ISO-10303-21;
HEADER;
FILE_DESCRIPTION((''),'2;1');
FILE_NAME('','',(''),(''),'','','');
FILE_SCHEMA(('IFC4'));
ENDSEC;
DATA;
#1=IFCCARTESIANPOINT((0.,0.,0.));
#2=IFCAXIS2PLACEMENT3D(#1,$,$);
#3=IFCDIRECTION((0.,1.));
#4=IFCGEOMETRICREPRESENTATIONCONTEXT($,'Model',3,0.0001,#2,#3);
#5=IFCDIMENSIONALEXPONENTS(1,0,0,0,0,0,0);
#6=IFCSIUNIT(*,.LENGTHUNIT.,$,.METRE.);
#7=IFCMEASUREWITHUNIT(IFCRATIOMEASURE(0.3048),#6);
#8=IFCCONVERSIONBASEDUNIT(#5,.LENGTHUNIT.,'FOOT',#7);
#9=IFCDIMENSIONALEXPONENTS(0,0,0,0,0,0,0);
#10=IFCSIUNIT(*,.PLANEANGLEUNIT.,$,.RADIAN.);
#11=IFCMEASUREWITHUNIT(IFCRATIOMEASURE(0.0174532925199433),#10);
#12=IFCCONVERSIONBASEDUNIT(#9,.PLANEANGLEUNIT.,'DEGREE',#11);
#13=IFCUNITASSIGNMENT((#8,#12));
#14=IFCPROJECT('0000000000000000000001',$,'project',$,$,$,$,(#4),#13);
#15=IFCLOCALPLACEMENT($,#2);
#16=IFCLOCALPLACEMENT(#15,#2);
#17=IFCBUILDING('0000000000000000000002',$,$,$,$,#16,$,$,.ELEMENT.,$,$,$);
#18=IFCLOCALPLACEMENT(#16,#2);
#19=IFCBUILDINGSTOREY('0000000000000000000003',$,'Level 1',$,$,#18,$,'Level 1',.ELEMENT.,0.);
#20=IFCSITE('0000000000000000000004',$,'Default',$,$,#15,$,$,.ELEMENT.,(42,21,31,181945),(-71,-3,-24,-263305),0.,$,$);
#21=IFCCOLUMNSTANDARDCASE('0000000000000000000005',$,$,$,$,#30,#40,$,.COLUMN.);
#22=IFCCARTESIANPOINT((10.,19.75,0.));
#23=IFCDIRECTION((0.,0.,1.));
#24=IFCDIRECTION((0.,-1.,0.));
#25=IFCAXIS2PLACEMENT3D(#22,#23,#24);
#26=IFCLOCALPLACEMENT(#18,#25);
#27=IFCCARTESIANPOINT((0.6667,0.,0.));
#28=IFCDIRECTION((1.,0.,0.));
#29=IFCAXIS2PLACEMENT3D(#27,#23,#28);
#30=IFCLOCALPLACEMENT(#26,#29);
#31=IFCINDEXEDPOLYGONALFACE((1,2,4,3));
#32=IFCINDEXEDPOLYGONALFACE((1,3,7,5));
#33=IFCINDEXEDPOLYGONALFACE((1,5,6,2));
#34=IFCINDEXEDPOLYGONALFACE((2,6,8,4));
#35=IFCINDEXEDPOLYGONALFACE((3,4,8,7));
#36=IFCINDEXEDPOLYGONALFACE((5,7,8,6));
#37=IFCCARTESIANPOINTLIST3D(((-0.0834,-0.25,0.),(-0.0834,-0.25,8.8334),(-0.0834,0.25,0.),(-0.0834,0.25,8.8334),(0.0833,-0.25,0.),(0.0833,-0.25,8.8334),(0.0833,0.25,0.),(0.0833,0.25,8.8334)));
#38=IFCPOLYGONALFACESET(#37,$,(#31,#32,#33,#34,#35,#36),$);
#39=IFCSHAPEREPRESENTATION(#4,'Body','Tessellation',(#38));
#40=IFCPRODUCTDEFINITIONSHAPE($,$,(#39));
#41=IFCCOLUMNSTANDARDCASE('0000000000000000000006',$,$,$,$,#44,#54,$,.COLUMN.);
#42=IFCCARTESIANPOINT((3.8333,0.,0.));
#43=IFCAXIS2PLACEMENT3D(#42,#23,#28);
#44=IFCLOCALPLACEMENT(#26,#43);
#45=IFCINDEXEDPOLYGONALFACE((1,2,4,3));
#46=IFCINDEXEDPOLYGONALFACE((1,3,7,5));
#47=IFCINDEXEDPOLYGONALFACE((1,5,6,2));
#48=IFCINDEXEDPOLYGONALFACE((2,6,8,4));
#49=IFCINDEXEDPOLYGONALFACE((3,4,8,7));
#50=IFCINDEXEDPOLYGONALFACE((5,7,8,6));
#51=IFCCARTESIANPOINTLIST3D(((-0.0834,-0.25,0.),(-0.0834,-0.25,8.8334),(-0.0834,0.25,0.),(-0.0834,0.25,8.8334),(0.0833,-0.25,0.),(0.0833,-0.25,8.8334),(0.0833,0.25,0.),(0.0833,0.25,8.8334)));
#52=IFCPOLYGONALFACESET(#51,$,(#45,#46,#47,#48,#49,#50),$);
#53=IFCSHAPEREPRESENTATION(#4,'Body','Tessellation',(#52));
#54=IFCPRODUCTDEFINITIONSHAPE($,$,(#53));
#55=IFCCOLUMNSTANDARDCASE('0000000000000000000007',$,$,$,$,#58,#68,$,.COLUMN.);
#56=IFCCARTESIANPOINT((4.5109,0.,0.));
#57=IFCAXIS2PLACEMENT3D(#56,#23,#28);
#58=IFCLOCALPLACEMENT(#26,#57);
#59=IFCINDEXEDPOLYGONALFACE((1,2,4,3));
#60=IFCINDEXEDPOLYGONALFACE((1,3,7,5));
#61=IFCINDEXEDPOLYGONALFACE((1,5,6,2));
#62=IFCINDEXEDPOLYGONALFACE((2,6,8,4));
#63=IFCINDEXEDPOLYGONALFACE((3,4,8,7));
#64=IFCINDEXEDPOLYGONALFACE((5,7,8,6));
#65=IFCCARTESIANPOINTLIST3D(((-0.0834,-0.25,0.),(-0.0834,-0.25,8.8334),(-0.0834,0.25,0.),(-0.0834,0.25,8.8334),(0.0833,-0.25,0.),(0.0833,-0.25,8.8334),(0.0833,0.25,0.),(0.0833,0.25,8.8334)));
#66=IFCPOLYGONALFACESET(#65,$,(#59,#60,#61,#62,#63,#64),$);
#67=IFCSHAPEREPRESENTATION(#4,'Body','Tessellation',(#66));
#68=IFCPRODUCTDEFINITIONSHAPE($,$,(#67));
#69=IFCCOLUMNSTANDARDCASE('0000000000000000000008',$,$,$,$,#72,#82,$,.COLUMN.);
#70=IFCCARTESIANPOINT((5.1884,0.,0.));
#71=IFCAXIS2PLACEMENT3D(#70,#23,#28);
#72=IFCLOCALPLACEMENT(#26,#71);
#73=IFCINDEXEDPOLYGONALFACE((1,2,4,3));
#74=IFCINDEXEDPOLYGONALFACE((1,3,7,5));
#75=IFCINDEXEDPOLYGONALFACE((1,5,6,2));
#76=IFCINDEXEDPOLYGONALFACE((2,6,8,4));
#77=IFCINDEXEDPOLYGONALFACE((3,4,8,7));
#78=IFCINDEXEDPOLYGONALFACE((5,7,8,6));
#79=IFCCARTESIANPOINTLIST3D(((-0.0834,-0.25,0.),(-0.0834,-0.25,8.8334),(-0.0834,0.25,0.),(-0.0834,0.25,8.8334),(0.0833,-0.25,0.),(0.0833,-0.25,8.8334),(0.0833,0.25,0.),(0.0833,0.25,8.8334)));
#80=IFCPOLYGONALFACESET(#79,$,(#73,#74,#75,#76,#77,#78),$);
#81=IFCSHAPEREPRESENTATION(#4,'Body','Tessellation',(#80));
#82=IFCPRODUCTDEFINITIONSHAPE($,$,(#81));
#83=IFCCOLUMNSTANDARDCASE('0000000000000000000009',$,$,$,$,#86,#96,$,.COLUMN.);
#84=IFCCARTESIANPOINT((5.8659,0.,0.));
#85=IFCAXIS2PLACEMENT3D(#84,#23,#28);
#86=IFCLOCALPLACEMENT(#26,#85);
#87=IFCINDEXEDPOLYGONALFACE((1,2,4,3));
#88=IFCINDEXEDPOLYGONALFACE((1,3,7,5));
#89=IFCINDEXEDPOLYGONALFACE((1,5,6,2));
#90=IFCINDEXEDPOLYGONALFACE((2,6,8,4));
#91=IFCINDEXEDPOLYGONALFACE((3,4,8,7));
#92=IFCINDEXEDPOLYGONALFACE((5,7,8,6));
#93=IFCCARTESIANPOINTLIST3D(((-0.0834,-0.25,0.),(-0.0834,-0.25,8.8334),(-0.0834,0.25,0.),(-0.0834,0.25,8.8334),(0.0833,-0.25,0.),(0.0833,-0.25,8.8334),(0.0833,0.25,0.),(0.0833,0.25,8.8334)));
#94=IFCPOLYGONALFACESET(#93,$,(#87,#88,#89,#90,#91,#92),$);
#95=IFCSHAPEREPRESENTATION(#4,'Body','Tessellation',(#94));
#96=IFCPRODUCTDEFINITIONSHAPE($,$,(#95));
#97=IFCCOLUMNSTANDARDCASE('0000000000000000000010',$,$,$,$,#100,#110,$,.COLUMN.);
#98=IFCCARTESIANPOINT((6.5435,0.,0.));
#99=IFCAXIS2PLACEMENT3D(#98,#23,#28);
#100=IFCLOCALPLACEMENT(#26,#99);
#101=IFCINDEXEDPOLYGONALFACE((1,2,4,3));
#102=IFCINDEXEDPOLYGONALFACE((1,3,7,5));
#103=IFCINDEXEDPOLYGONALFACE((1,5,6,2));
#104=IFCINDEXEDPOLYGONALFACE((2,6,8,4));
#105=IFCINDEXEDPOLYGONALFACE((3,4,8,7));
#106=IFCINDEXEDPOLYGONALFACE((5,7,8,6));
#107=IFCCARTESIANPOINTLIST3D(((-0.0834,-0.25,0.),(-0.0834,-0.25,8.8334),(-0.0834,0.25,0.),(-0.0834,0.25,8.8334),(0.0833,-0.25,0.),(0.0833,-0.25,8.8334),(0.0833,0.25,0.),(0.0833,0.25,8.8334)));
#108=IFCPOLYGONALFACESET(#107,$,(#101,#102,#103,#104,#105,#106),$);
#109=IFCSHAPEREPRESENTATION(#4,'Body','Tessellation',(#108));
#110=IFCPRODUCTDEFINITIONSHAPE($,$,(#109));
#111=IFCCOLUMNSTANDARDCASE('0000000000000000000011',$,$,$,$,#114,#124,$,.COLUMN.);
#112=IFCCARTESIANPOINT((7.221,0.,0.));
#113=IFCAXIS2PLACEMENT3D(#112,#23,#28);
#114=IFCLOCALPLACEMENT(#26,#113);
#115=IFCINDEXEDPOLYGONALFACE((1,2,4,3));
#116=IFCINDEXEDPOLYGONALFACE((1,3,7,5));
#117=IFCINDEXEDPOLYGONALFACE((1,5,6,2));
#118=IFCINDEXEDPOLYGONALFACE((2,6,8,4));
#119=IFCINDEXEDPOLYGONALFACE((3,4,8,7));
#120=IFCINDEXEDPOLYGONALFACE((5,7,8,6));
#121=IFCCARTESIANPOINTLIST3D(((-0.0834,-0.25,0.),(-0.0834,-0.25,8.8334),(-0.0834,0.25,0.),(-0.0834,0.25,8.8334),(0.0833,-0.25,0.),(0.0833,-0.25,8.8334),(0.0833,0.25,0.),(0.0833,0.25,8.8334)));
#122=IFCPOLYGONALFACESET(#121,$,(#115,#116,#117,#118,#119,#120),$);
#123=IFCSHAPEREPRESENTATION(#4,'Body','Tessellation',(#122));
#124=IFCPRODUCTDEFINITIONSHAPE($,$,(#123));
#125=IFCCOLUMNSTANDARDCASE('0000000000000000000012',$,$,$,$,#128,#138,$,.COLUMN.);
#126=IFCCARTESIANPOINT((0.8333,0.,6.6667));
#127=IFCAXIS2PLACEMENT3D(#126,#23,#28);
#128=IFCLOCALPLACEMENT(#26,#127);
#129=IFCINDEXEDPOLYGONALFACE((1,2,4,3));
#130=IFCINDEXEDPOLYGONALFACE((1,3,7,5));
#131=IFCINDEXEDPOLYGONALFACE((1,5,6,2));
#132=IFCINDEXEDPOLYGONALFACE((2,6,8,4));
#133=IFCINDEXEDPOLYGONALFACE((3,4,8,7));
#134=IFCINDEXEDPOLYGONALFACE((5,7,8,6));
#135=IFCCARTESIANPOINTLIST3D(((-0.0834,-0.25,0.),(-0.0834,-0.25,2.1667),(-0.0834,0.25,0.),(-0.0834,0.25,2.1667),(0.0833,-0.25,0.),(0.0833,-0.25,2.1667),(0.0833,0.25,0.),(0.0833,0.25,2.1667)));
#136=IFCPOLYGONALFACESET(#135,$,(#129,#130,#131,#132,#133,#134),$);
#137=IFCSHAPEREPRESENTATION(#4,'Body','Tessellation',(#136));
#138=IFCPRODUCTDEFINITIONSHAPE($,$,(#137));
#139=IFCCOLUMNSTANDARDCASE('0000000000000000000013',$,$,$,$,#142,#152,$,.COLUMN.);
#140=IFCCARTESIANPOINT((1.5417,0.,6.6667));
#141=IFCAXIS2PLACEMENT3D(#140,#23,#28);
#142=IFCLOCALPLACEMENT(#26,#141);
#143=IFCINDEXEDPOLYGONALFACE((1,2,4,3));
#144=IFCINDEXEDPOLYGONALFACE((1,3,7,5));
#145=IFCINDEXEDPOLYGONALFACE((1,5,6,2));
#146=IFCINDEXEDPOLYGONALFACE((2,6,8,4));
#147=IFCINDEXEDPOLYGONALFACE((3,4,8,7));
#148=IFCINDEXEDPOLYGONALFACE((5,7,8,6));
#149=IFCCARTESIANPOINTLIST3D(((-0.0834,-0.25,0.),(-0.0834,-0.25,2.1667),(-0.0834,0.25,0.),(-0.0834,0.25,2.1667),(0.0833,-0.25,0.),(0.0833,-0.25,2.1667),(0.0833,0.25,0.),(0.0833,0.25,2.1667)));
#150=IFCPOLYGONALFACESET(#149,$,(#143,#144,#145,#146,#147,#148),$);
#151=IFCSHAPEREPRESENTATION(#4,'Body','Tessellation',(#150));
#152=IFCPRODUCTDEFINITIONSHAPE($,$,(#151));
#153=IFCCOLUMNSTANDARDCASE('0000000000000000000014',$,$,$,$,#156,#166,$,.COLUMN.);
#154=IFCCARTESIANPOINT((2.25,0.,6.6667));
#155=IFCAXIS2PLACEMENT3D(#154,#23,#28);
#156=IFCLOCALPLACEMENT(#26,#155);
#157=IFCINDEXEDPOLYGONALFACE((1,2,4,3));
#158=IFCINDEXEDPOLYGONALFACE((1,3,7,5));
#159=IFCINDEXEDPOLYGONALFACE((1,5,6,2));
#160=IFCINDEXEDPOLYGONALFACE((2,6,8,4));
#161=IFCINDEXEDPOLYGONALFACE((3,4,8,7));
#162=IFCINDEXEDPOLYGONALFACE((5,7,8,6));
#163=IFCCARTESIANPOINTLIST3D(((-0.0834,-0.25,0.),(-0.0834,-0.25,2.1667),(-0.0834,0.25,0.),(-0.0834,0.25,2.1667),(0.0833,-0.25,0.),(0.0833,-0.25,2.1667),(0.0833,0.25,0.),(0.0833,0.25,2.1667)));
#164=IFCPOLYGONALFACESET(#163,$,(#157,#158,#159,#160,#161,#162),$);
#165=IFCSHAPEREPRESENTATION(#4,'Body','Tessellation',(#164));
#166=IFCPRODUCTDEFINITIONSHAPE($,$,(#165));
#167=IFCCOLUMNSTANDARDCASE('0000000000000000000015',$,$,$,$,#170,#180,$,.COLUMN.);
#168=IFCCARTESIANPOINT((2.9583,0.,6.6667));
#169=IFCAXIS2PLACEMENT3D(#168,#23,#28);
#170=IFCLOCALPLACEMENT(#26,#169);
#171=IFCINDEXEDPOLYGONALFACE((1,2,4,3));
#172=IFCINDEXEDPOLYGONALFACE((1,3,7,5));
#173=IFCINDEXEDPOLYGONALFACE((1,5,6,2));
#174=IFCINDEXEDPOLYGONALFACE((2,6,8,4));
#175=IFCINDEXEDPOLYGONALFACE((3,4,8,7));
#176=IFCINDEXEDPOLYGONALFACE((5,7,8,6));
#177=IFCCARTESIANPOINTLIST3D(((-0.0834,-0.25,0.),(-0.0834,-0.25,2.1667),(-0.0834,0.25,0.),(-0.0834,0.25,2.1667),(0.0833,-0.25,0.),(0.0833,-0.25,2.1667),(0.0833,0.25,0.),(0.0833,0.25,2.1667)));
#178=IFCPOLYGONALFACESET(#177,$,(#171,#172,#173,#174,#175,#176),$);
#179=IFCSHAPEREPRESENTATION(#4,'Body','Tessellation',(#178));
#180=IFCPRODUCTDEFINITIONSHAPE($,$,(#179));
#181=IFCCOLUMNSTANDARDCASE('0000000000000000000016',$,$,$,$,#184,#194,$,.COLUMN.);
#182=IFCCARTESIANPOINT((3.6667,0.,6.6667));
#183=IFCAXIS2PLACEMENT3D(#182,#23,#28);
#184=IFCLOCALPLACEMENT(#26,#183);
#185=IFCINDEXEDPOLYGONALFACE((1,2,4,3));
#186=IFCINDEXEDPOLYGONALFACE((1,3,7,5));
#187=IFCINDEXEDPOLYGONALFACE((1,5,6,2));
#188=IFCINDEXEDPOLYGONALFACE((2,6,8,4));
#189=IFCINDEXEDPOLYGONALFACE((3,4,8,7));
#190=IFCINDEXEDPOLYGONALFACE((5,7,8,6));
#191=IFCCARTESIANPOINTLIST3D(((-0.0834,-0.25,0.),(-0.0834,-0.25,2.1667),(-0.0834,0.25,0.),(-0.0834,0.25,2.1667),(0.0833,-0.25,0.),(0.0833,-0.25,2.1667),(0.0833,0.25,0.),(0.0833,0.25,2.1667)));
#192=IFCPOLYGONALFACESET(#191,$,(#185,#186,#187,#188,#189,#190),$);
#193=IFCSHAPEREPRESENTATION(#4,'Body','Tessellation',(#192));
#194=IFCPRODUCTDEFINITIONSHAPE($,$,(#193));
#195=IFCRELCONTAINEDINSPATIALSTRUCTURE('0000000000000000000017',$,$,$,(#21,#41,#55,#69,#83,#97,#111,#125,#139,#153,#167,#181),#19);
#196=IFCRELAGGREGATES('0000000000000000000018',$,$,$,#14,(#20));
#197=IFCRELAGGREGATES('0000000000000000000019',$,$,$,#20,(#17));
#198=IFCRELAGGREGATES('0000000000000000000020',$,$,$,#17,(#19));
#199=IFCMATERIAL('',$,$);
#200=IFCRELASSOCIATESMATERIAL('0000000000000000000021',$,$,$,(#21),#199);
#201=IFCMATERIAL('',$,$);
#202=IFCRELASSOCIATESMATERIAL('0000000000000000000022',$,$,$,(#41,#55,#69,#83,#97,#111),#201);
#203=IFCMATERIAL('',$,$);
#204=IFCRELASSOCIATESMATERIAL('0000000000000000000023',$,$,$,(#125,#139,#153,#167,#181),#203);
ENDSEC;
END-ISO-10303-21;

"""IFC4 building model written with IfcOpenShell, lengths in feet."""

from ifc_helpers import new_model, entity, si_unit, converted_unit, direction, frame, origin, place, context, project, spatial, rectangle, extrude, material, element, save


model = new_model("IFC4")

# Units and contexts
model_context = context("Model", 3, precision=0.0001, world=origin(), true_north=direction((0.0, 1.0)))
ifc_project = project(units=[converted_unit("LENGTHUNIT", "FOOT", entity("IfcRatioMeasure", 0.3048), si_unit("LENGTHUNIT", "METRE"), dimensions=[1, 0, 0, 0, 0, 0, 0]), converted_unit("PLANEANGLEUNIT", "DEGREE", entity("IfcRatioMeasure", 0.0174532925199433), si_unit("PLANEANGLEUNIT", "RADIAN"), dimensions=[0, 0, 0, 0, 0, 0, 0])], contexts=[model_context])

# Site, building, storey
site_placement = place(None, origin())
site = spatial("IfcSite", under=ifc_project, at=site_placement, Name="Default", CompositionType="ELEMENT", RefLatitude=(42, 21, 31, 181945), RefLongitude=(-71, -3, -24, -263305), RefElevation=0.0)
building_placement = place(site_placement, origin())
building = spatial("IfcBuilding", under=site, at=building_placement, CompositionType="ELEMENT")
storey_placement = place(building_placement, origin())
storey = spatial("IfcBuildingStorey", under=building, at=storey_placement, Name="Level 1", LongName="Level 1", CompositionType="ELEMENT", Elevation=0.0)

# Columns
ifc_material_1 = material(Name="")
ifc_material_2 = material(Name="")
placement_1 = place(storey_placement, frame((10.0, 19.75, 0.0), z_axis=(0.0, 0.0, 1.0), x_axis=(0.0, -1.0, 0.0)))
for number, where, z_axis, x_axis in (
    (1, (0.6667, 0.0, 0.0), (0.0, 0.0, 1.0), (1.0, 0.0, 0.0)),
):
    element("IfcColumnStandardCase", number, at=place(placement_1, frame(where, z_axis=z_axis, x_axis=x_axis)), inside=storey, material=ifc_material_1, PredefinedType="COLUMN", context=model_context, shape_type="SweptSolid", body=[
        extrude(rectangle(XDim=0.1667, YDim=0.5), origin(), (0.0, 0.0, 1.0), 8.8334),
    ])
for number, where, z_axis, x_axis in (
    (2, (3.8333, 0.0, 0.0), (0.0, 0.0, 1.0), (1.0, 0.0, 0.0)),
    (3, (4.5109, 0.0, 0.0), (0.0, 0.0, 1.0), (1.0, 0.0, 0.0)),
    (4, (5.1884, 0.0, 0.0), (0.0, 0.0, 1.0), (1.0, 0.0, 0.0)),
    (5, (5.8659, 0.0, 0.0), (0.0, 0.0, 1.0), (1.0, 0.0, 0.0)),
    (6, (6.5435, 0.0, 0.0), (0.0, 0.0, 1.0), (1.0, 0.0, 0.0)),
    (7, (7.221, 0.0, 0.0), (0.0, 0.0, 1.0), (1.0, 0.0, 0.0)),
):
    element("IfcColumnStandardCase", number, at=place(placement_1, frame(where, z_axis=z_axis, x_axis=x_axis)), inside=storey, material=ifc_material_2, PredefinedType="COLUMN", context=model_context, shape_type="SweptSolid", body=[
        extrude(rectangle(XDim=0.1667, YDim=0.5), origin(), (0.0, 0.0, 1.0), 8.8334),
    ])
ifc_material_3 = material(Name="")
for number, where, z_axis, x_axis in (
    (8, (0.8333, 0.0, 6.6667), (0.0, 0.0, 1.0), (1.0, 0.0, 0.0)),
    (9, (1.5417, 0.0, 6.6667), (0.0, 0.0, 1.0), (1.0, 0.0, 0.0)),
    (10, (2.25, 0.0, 6.6667), (0.0, 0.0, 1.0), (1.0, 0.0, 0.0)),
    (11, (2.9583, 0.0, 6.6667), (0.0, 0.0, 1.0), (1.0, 0.0, 0.0)),
    (12, (3.6667, 0.0, 6.6667), (0.0, 0.0, 1.0), (1.0, 0.0, 0.0)),
):
    element("IfcColumnStandardCase", number, at=place(placement_1, frame(where, z_axis=z_axis, x_axis=x_axis)), inside=storey, material=ifc_material_3, PredefinedType="COLUMN", context=model_context, shape_type="SweptSolid", body=[
        extrude(rectangle(XDim=0.1667, YDim=0.5), origin(), (0.0, 0.0, 1.0), 2.1667),
    ])

save(model, "model.ifc")
